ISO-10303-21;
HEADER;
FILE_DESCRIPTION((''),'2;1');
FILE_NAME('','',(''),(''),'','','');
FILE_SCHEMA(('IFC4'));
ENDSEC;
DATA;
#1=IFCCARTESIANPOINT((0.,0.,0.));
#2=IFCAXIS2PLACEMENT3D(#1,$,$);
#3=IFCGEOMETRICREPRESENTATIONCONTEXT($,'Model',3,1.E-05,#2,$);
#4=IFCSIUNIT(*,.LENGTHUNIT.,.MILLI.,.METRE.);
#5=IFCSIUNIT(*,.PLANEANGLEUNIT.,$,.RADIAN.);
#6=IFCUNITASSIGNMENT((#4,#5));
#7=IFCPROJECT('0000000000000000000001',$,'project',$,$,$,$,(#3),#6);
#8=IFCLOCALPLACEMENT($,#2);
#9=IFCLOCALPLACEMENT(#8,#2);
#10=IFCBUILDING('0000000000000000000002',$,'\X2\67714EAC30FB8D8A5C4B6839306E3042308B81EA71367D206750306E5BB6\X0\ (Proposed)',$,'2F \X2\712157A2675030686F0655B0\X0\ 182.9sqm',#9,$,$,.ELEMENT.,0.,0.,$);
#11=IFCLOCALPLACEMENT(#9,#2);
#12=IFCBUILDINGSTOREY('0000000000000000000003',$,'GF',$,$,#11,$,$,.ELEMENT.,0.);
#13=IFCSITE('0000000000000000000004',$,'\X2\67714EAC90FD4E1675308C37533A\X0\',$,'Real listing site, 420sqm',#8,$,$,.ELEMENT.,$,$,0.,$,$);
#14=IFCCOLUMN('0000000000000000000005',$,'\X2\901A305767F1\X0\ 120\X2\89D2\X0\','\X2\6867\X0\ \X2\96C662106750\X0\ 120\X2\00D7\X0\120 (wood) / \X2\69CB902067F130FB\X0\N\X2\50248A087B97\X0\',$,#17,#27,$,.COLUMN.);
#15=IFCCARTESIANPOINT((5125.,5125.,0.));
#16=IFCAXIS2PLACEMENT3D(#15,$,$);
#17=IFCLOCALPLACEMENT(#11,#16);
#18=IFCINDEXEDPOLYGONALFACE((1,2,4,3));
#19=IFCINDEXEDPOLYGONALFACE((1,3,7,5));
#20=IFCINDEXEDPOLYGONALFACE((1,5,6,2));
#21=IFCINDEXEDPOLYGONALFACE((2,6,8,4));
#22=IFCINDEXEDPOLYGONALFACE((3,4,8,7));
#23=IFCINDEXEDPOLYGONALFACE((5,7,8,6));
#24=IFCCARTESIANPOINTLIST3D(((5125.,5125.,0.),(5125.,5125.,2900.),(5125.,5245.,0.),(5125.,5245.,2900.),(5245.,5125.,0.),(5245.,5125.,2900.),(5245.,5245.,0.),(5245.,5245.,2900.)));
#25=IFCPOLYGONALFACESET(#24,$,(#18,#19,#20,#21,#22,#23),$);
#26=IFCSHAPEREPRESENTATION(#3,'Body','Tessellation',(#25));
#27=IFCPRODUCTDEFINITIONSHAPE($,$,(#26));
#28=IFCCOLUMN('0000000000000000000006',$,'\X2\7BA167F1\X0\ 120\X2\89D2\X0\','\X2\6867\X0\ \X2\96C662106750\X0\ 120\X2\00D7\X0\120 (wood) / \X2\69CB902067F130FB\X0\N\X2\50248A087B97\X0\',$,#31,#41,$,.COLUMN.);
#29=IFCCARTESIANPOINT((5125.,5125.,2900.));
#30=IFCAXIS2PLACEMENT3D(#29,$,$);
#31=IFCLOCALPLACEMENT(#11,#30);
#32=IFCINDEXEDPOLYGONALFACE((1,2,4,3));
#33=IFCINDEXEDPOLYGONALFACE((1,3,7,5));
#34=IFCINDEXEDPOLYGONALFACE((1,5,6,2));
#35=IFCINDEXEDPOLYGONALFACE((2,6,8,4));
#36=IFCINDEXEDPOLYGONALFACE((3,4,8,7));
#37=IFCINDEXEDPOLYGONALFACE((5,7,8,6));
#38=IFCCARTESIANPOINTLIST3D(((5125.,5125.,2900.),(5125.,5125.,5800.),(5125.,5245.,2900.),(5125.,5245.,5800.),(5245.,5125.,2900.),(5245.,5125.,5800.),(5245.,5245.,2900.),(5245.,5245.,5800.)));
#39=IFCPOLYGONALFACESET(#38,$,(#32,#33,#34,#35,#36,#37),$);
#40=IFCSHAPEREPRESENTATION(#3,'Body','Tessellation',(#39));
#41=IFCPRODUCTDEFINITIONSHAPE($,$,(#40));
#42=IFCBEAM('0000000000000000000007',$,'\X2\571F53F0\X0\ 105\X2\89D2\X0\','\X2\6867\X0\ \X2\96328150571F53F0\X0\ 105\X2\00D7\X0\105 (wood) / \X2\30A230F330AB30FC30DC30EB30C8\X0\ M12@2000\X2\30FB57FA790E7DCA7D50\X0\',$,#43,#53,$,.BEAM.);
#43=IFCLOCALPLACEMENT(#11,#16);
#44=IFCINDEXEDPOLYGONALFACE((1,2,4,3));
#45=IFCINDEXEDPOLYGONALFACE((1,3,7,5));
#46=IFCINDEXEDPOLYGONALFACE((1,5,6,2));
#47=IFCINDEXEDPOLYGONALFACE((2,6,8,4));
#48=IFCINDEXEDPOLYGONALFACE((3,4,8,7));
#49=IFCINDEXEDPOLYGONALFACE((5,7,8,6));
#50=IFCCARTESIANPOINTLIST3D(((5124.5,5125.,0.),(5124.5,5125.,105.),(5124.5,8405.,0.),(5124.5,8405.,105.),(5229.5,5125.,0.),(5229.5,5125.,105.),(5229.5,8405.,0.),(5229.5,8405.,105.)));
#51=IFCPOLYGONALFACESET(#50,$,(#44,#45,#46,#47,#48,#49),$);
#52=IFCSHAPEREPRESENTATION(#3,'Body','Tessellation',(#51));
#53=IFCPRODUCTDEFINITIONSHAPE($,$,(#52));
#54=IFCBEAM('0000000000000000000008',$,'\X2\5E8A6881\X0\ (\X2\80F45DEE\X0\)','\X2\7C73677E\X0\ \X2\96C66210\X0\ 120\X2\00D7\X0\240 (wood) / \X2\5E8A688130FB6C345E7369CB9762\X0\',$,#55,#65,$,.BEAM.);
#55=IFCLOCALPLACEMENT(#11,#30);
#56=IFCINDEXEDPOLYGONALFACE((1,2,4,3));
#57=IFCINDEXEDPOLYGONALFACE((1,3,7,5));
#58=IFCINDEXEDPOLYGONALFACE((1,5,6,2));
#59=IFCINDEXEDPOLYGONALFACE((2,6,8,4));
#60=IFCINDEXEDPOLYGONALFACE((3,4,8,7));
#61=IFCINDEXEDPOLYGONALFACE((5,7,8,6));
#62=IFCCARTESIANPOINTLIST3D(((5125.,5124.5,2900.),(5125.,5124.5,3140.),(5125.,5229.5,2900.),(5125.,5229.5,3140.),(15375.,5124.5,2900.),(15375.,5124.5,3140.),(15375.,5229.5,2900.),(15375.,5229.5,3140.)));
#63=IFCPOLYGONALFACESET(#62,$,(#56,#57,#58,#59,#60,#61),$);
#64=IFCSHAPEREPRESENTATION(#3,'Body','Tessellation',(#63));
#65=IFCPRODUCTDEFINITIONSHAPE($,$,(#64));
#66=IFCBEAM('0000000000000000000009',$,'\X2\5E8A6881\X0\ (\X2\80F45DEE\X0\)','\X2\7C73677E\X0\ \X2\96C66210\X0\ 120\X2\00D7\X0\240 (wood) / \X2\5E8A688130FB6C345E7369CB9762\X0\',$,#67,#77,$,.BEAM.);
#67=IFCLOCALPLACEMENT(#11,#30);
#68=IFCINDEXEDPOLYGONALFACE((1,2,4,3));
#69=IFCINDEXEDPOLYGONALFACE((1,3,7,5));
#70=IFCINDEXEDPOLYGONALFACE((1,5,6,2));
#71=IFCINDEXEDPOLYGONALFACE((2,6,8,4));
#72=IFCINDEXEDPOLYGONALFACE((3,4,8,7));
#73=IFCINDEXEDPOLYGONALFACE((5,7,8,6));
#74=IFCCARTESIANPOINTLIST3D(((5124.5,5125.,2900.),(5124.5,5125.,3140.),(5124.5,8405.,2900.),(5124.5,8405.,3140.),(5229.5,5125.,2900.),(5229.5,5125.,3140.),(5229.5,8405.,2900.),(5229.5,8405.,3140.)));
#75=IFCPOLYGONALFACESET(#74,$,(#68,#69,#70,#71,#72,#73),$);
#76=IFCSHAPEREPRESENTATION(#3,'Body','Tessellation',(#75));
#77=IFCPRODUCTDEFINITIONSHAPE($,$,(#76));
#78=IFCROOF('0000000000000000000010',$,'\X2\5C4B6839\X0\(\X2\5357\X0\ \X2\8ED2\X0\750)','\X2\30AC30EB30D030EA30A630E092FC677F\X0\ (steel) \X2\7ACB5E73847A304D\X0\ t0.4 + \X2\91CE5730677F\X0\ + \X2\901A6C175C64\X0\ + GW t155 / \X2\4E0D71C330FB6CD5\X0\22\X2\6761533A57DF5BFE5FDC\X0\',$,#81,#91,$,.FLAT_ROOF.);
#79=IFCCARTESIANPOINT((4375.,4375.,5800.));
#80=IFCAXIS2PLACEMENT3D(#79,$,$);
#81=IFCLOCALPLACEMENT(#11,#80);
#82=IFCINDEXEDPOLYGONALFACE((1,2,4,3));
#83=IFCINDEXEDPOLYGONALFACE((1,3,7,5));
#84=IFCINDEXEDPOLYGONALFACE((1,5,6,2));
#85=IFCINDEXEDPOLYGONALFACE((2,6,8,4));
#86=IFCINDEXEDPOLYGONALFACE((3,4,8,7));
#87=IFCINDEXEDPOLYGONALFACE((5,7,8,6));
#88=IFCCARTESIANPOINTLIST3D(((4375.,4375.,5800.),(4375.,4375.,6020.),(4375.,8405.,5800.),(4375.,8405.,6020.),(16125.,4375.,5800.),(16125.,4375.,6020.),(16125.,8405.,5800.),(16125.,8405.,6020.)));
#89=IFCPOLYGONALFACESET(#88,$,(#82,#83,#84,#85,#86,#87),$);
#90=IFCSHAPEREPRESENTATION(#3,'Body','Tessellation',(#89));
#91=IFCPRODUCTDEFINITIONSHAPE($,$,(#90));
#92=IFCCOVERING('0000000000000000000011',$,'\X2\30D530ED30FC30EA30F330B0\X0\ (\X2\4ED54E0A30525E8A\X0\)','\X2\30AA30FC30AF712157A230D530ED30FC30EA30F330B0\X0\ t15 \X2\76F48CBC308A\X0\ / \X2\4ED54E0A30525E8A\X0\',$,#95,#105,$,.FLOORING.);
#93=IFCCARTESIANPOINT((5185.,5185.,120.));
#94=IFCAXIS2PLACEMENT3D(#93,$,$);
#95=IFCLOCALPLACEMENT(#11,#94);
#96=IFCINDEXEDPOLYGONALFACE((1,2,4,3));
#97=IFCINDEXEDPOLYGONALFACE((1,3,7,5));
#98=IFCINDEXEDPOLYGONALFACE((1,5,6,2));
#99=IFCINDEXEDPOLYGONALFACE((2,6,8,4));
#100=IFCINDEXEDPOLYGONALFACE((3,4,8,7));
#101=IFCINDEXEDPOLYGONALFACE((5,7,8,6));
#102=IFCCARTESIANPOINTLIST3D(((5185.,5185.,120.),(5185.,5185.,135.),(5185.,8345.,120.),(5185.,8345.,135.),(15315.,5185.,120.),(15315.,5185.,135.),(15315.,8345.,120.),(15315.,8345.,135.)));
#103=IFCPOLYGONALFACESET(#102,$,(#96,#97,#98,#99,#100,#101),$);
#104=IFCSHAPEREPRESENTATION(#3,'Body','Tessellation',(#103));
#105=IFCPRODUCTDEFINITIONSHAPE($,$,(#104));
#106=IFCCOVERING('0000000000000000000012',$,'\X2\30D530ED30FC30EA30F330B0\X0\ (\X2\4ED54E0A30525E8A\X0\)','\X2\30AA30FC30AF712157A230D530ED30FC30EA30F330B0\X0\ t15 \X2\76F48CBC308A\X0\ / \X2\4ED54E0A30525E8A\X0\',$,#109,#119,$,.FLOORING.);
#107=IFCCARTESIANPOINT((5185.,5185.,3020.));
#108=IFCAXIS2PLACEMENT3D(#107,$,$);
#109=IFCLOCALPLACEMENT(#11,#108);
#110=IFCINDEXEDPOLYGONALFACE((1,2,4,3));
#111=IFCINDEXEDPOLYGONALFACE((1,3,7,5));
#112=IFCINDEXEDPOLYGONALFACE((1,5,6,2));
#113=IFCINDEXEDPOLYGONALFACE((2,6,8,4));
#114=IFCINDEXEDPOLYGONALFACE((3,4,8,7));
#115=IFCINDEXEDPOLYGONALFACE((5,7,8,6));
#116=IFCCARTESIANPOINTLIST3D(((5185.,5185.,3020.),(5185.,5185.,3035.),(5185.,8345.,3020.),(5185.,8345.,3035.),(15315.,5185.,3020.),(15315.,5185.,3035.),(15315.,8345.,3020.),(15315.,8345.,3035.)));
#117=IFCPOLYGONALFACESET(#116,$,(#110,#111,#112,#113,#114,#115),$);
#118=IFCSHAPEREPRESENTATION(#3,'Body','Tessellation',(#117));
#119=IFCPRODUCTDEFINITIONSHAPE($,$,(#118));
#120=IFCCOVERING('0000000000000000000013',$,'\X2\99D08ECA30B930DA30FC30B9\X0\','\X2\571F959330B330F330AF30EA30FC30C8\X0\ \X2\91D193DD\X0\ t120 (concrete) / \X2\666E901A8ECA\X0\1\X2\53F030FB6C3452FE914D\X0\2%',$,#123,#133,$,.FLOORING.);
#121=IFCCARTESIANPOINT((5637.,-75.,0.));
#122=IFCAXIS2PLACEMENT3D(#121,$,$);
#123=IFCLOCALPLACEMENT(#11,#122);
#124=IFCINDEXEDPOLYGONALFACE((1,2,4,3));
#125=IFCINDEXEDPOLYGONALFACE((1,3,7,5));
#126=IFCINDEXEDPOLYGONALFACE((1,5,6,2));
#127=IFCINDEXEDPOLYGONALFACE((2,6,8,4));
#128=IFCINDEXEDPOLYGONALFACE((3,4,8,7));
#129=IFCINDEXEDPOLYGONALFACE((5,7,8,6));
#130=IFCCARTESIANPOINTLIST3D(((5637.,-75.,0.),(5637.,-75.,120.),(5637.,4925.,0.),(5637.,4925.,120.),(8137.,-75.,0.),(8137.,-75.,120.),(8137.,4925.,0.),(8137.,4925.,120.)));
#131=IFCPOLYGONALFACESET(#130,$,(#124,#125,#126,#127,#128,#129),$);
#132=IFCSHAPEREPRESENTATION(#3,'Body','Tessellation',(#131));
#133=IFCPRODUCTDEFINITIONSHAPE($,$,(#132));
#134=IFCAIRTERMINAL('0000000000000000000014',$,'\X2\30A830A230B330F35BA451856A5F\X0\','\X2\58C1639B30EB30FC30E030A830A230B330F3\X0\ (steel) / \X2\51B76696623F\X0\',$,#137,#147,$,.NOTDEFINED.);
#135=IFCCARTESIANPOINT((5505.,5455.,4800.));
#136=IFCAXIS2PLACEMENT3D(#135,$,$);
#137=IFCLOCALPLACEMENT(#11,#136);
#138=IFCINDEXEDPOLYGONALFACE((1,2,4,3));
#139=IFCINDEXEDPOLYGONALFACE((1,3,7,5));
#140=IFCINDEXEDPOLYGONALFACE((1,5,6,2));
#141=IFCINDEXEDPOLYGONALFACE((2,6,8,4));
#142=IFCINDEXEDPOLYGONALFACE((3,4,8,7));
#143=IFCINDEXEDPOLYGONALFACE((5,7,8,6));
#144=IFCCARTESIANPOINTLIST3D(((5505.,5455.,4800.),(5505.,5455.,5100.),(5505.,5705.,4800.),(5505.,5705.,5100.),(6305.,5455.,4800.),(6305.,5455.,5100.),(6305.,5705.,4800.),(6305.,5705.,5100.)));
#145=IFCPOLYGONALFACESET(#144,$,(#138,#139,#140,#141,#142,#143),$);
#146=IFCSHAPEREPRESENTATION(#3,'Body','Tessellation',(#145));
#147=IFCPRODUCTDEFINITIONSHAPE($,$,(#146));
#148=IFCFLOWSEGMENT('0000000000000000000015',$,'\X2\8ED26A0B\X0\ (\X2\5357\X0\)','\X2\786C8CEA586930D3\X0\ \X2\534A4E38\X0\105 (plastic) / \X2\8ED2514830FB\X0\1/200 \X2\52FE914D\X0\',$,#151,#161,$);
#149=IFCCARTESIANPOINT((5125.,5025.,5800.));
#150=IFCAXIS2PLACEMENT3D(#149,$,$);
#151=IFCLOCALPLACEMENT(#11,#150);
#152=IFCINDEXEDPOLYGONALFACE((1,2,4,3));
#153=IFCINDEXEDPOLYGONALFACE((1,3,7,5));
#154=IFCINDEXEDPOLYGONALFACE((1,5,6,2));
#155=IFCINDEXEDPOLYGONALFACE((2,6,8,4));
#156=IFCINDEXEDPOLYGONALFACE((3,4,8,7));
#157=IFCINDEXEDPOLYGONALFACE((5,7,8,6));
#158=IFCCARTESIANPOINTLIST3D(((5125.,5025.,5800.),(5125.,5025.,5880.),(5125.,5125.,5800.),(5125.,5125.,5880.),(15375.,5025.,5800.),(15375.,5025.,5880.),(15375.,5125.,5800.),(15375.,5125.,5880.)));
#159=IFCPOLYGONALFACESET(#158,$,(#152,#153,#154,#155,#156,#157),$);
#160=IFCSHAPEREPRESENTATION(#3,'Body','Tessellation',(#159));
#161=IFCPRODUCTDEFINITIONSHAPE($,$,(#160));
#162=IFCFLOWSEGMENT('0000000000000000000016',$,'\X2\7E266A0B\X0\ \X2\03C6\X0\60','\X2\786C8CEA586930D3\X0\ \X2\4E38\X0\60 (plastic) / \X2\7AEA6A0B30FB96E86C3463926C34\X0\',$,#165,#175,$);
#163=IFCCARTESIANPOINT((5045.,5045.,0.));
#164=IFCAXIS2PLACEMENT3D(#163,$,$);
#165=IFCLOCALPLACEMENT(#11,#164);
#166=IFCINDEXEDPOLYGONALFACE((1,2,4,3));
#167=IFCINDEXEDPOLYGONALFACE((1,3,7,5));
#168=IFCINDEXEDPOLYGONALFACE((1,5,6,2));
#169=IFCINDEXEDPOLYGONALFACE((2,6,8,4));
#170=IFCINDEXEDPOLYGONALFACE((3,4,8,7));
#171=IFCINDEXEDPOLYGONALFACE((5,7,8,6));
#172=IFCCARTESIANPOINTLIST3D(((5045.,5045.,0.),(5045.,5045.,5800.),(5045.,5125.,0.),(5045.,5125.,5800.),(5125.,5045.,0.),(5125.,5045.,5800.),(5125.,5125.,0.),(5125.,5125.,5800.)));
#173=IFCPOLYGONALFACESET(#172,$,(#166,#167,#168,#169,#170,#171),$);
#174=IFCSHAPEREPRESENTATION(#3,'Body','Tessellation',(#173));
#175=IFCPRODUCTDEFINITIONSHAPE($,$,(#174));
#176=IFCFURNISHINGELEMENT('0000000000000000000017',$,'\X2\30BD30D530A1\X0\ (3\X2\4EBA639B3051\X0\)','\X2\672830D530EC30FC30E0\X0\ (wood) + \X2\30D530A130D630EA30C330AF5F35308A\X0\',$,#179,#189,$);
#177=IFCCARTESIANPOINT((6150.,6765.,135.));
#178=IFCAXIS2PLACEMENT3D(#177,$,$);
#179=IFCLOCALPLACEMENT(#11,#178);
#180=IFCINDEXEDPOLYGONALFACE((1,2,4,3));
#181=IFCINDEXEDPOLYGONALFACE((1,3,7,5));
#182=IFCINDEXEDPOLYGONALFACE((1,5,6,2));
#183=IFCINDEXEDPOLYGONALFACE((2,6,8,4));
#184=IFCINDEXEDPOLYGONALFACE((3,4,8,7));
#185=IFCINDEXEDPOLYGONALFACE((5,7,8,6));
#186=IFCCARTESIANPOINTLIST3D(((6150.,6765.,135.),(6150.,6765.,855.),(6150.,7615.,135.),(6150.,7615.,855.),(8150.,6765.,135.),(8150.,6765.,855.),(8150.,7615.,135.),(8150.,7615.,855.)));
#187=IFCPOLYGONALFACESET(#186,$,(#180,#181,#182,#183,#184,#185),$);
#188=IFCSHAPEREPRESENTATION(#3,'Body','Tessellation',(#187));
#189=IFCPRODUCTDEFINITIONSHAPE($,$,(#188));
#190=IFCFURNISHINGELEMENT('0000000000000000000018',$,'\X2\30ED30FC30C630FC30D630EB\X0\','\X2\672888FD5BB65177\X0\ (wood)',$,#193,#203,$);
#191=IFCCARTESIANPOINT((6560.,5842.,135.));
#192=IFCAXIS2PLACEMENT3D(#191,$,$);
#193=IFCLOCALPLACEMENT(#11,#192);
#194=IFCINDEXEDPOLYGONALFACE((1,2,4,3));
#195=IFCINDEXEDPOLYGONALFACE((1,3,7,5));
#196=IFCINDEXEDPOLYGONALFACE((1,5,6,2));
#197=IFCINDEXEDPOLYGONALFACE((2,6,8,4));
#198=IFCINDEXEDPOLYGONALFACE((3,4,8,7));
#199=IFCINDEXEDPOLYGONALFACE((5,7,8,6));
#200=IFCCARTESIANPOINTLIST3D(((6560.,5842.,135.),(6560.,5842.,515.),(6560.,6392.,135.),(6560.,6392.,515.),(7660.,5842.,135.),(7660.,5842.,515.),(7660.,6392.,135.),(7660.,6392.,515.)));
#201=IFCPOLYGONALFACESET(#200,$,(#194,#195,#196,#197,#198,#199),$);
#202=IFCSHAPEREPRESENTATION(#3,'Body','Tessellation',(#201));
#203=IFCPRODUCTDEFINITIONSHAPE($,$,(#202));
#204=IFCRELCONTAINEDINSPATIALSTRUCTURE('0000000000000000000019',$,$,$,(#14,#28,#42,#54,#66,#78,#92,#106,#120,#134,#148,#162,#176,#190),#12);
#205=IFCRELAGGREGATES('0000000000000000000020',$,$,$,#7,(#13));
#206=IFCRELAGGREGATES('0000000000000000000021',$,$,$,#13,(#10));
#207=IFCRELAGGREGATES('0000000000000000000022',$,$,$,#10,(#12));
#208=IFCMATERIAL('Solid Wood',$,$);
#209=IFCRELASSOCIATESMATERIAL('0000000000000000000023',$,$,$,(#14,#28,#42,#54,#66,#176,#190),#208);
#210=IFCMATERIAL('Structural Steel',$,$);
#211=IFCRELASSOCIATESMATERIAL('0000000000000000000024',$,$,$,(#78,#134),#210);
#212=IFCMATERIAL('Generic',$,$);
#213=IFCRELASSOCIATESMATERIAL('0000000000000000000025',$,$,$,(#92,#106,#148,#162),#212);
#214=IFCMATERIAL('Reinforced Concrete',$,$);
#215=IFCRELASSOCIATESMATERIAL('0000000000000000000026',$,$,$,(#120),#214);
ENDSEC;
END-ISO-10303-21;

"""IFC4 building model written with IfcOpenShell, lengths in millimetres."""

from ifc_helpers import new_model, si_unit, frame, frame_2d, origin, place, context, project, spatial, rectangle, extrude, material, element, save


model = new_model("IFC4")

# Units and contexts
model_context = context("Model", 3, precision=1e-05, world=origin())
ifc_project = project(units=[si_unit("LENGTHUNIT", "METRE", prefix="MILLI"), si_unit("PLANEANGLEUNIT", "RADIAN")], contexts=[model_context])

# Site, building, storey
site_placement = place(None, origin())
site = spatial("IfcSite", under=ifc_project, at=site_placement, Name="東京都世田谷区", ObjectType="Real listing site, 420sqm", CompositionType="ELEMENT", RefElevation=0.0)
building_placement = place(site_placement, origin())
building = spatial("IfcBuilding", under=site, at=building_placement, Name="東京・越屋根のある自然素材の家 (Proposed)", ObjectType="2F 無垢材と漆喰 182.9sqm", CompositionType="ELEMENT", ElevationOfRefHeight=0.0, ElevationOfTerrain=0.0)
storey_placement = place(building_placement, origin())
storey = spatial("IfcBuildingStorey", under=building, at=storey_placement, Name="GF", CompositionType="ELEMENT", Elevation=0.0)

# Columns
ifc_material_1 = material(Name="Solid Wood")
column_1_placement = place(storey_placement, frame((5125.0, 5125.0, 0.0)))
element("IfcColumn", 1, at=column_1_placement, inside=storey, material=ifc_material_1, Name="通し柱 120角", Description="桧 集成材 120×120 (wood) / 構造柱・N値計算", PredefinedType="COLUMN", context=model_context, shape_type="SweptSolid", body=[
    extrude(rectangle(XDim=120.0, YDim=120.0, at=frame_2d((60.0, 60.0))), frame((5125.0, 5125.0, 0.0)), (0.0, 0.0, 1.0), 2900.0),
])
column_2_placement = place(storey_placement, frame((5125.0, 5125.0, 2900.0)))
element("IfcColumn", 2, at=column_2_placement, inside=storey, material=ifc_material_1, Name="管柱 120角", Description="桧 集成材 120×120 (wood) / 構造柱・N値計算", PredefinedType="COLUMN", context=model_context, shape_type="SweptSolid", body=[
    extrude(rectangle(XDim=120.0, YDim=120.0, at=frame_2d((60.0, 60.0))), frame((5125.0, 5125.0, 2900.0)), (0.0, 0.0, 1.0), 2900.0),
])

# Beams
beam_1_placement = place(storey_placement, frame((5125.0, 5125.0, 0.0)))
element("IfcBeam", 3, at=beam_1_placement, inside=storey, material=ifc_material_1, Name="土台 105角", Description="桧 防腐土台 105×105 (wood) / アンカーボルト M12@2000・基礎緊結", PredefinedType="BEAM", context=model_context, shape_type="SweptSolid", body=[
    extrude(rectangle(XDim=105.0, YDim=3280.0, at=frame_2d((52.0, 1640.0))), frame((5125.0, 5125.0, 0.0)), (0.0, 0.0, 1.0), 105.0),
])
beam_2_placement = place(storey_placement, frame((5125.0, 5125.0, 2900.0)))
element("IfcBeam", 4, at=beam_2_placement, inside=storey, material=ifc_material_1, Name="床梁 (胴差)", Description="米松 集成 120×240 (wood) / 床梁・水平構面", PredefinedType="BEAM", context=model_context, shape_type="SweptSolid", body=[
    extrude(rectangle(XDim=10250.0, YDim=105.0, at=frame_2d((5125.0, 52.0))), frame((5125.0, 5125.0, 2900.0)), (0.0, 0.0, 1.0), 240.0),
])
beam_3_placement = place(storey_placement, frame((5125.0, 5125.0, 2900.0)))
element("IfcBeam", 5, at=beam_3_placement, inside=storey, material=ifc_material_1, Name="床梁 (胴差)", Description="米松 集成 120×240 (wood) / 床梁・水平構面", PredefinedType="BEAM", context=model_context, shape_type="SweptSolid", body=[
    extrude(rectangle(XDim=105.0, YDim=3280.0, at=frame_2d((52.0, 1640.0))), frame((5125.0, 5125.0, 2900.0)), (0.0, 0.0, 1.0), 240.0),
])

# Shared definitions
ifc_material_2 = material(Name="Reinforced Concrete")

# Roof
ifc_material_3 = material(Name="Structural Steel")
for number, where, name in (
    (6, (4375.0, 4375.0, 5800.0), "屋根(南 軒750)"),
):
    element("IfcRoof", number, at=place(storey_placement, frame(where)), inside=storey, material=ifc_material_3, Name=name, Description="ガルバリウム鋼板 (steel) 立平葺き t0.4 + 野地板 + 通気層 + GW t155 / 不燃・法22条区域対応", PredefinedType="FLAT_ROOF", context=model_context, shape_type="SweptSolid", body=[
        extrude(rectangle(XDim=11750.0, YDim=4030.0, at=frame_2d((5875.0, 2015.0))), frame((4375.0, 4375.0, 5800.0)), (0.0, 0.0, 1.0), 220.0),
    ])

# Coverings
ifc_material_4 = material(Name="Generic")
covering_1_placement = place(storey_placement, frame((5185.0, 5185.0, 120.0)))
element("IfcCovering", 7, at=covering_1_placement, inside=storey, material=ifc_material_4, Name="フローリング (仕上げ床)", Description="オーク無垢フローリング t15 直貼り / 仕上げ床", PredefinedType="FLOORING", context=model_context, shape_type="SweptSolid", body=[
    extrude(rectangle(XDim=10130.0, YDim=3160.0, at=frame_2d((5065.0, 1580.0))), frame((5185.0, 5185.0, 120.0)), (0.0, 0.0, 1.0), 15.0),
])
covering_2_placement = place(storey_placement, frame((5185.0, 5185.0, 3020.0)))
element("IfcCovering", 8, at=covering_2_placement, inside=storey, material=ifc_material_4, Name="フローリング (仕上げ床)", Description="オーク無垢フローリング t15 直貼り / 仕上げ床", PredefinedType="FLOORING", context=model_context, shape_type="SweptSolid", body=[
    extrude(rectangle(XDim=10130.0, YDim=3160.0, at=frame_2d((5065.0, 1580.0))), frame((5185.0, 5185.0, 3020.0)), (0.0, 0.0, 1.0), 15.0),
])
covering_3_placement = place(storey_placement, frame((5637.0, -75.0, 0.0)))
element("IfcCovering", 9, at=covering_3_placement, inside=storey, material=ifc_material_2, Name="駐車スペース", Description="土間コンクリート 金鏝 t120 (concrete) / 普通車1台・水勾配2%", PredefinedType="FLOORING", context=model_context, shape_type="SweptSolid", body=[
    extrude(rectangle(XDim=2500.0, YDim=5000.0, at=frame_2d((1250.0, 2500.0))), frame((5637.0, -75.0, 0.0)), (0.0, 0.0, 1.0), 120.0),
])

# Air terminal
air_terminal_placement = place(storey_placement, frame((5505.0, 5455.0, 4800.0)))
element("IfcAirTerminal", 10, at=air_terminal_placement, inside=storey, material=ifc_material_3, Name="エアコン室内機", Description="壁掛ルームエアコン (steel) / 冷暖房", PredefinedType="NOTDEFINED", context=model_context, shape_type="SweptSolid", body=[
    extrude(rectangle(XDim=800.0, YDim=250.0, at=frame_2d((400.0, 125.0))), frame((5505.0, 5455.0, 4800.0)), (0.0, 0.0, 1.0), 300.0),
])

# Flow segments
flow_segment_1_placement = place(storey_placement, frame((5125.0, 5025.0, 5800.0)))
element("IfcFlowSegment", 11, at=flow_segment_1_placement, inside=storey, material=ifc_material_4, Name="軒樋 (南)", Description="硬質塩ビ 半丸105 (plastic) / 軒先・1/200 勾配", context=model_context, shape_type="SweptSolid", body=[
    extrude(rectangle(XDim=10250.0, YDim=100.0, at=frame_2d((5125.0, 50.0))), frame((5125.0, 5025.0, 5800.0)), (0.0, 0.0, 1.0), 80.0),
])
flow_segment_2_placement = place(storey_placement, frame((5045.0, 5045.0, 0.0)))
element("IfcFlowSegment", 12, at=flow_segment_2_placement, inside=storey, material=ifc_material_4, Name="縦樋 φ60", Description="硬質塩ビ 丸60 (plastic) / 竪樋・雨水排水", context=model_context, shape_type="SweptSolid", body=[
    extrude(rectangle(XDim=80.0, YDim=80.0, at=frame_2d((40.0, 40.0))), frame((5045.0, 5045.0, 0.0)), (0.0, 0.0, 1.0), 5800.0),
])

# Furnishing elements
furnishing_1_placement = place(storey_placement, frame((6150.0, 6765.0, 135.0)))
element("IfcFurnishingElement", 13, at=furnishing_1_placement, inside=storey, material=ifc_material_1, Name="ソファ (3人掛け)", Description="木フレーム (wood) + ファブリック張り", context=model_context, shape_type="SweptSolid", body=[
    extrude(rectangle(XDim=2000.0, YDim=850.0, at=frame_2d((1000.0, 425.0))), frame((6150.0, 6765.0, 135.0)), (0.0, 0.0, 1.0), 720.0),
])
furnishing_2_placement = place(storey_placement, frame((6560.0, 5842.0, 135.0)))
element("IfcFurnishingElement", 14, at=furnishing_2_placement, inside=storey, material=ifc_material_1, Name="ローテーブル", Description="木製家具 (wood)", context=model_context, shape_type="SweptSolid", body=[
    extrude(rectangle(XDim=1100.0, YDim=550.0, at=frame_2d((550.0, 275.0))), frame((6560.0, 5842.0, 135.0)), (0.0, 0.0, 1.0), 380.0),
])

save(model, "model.ifc")
